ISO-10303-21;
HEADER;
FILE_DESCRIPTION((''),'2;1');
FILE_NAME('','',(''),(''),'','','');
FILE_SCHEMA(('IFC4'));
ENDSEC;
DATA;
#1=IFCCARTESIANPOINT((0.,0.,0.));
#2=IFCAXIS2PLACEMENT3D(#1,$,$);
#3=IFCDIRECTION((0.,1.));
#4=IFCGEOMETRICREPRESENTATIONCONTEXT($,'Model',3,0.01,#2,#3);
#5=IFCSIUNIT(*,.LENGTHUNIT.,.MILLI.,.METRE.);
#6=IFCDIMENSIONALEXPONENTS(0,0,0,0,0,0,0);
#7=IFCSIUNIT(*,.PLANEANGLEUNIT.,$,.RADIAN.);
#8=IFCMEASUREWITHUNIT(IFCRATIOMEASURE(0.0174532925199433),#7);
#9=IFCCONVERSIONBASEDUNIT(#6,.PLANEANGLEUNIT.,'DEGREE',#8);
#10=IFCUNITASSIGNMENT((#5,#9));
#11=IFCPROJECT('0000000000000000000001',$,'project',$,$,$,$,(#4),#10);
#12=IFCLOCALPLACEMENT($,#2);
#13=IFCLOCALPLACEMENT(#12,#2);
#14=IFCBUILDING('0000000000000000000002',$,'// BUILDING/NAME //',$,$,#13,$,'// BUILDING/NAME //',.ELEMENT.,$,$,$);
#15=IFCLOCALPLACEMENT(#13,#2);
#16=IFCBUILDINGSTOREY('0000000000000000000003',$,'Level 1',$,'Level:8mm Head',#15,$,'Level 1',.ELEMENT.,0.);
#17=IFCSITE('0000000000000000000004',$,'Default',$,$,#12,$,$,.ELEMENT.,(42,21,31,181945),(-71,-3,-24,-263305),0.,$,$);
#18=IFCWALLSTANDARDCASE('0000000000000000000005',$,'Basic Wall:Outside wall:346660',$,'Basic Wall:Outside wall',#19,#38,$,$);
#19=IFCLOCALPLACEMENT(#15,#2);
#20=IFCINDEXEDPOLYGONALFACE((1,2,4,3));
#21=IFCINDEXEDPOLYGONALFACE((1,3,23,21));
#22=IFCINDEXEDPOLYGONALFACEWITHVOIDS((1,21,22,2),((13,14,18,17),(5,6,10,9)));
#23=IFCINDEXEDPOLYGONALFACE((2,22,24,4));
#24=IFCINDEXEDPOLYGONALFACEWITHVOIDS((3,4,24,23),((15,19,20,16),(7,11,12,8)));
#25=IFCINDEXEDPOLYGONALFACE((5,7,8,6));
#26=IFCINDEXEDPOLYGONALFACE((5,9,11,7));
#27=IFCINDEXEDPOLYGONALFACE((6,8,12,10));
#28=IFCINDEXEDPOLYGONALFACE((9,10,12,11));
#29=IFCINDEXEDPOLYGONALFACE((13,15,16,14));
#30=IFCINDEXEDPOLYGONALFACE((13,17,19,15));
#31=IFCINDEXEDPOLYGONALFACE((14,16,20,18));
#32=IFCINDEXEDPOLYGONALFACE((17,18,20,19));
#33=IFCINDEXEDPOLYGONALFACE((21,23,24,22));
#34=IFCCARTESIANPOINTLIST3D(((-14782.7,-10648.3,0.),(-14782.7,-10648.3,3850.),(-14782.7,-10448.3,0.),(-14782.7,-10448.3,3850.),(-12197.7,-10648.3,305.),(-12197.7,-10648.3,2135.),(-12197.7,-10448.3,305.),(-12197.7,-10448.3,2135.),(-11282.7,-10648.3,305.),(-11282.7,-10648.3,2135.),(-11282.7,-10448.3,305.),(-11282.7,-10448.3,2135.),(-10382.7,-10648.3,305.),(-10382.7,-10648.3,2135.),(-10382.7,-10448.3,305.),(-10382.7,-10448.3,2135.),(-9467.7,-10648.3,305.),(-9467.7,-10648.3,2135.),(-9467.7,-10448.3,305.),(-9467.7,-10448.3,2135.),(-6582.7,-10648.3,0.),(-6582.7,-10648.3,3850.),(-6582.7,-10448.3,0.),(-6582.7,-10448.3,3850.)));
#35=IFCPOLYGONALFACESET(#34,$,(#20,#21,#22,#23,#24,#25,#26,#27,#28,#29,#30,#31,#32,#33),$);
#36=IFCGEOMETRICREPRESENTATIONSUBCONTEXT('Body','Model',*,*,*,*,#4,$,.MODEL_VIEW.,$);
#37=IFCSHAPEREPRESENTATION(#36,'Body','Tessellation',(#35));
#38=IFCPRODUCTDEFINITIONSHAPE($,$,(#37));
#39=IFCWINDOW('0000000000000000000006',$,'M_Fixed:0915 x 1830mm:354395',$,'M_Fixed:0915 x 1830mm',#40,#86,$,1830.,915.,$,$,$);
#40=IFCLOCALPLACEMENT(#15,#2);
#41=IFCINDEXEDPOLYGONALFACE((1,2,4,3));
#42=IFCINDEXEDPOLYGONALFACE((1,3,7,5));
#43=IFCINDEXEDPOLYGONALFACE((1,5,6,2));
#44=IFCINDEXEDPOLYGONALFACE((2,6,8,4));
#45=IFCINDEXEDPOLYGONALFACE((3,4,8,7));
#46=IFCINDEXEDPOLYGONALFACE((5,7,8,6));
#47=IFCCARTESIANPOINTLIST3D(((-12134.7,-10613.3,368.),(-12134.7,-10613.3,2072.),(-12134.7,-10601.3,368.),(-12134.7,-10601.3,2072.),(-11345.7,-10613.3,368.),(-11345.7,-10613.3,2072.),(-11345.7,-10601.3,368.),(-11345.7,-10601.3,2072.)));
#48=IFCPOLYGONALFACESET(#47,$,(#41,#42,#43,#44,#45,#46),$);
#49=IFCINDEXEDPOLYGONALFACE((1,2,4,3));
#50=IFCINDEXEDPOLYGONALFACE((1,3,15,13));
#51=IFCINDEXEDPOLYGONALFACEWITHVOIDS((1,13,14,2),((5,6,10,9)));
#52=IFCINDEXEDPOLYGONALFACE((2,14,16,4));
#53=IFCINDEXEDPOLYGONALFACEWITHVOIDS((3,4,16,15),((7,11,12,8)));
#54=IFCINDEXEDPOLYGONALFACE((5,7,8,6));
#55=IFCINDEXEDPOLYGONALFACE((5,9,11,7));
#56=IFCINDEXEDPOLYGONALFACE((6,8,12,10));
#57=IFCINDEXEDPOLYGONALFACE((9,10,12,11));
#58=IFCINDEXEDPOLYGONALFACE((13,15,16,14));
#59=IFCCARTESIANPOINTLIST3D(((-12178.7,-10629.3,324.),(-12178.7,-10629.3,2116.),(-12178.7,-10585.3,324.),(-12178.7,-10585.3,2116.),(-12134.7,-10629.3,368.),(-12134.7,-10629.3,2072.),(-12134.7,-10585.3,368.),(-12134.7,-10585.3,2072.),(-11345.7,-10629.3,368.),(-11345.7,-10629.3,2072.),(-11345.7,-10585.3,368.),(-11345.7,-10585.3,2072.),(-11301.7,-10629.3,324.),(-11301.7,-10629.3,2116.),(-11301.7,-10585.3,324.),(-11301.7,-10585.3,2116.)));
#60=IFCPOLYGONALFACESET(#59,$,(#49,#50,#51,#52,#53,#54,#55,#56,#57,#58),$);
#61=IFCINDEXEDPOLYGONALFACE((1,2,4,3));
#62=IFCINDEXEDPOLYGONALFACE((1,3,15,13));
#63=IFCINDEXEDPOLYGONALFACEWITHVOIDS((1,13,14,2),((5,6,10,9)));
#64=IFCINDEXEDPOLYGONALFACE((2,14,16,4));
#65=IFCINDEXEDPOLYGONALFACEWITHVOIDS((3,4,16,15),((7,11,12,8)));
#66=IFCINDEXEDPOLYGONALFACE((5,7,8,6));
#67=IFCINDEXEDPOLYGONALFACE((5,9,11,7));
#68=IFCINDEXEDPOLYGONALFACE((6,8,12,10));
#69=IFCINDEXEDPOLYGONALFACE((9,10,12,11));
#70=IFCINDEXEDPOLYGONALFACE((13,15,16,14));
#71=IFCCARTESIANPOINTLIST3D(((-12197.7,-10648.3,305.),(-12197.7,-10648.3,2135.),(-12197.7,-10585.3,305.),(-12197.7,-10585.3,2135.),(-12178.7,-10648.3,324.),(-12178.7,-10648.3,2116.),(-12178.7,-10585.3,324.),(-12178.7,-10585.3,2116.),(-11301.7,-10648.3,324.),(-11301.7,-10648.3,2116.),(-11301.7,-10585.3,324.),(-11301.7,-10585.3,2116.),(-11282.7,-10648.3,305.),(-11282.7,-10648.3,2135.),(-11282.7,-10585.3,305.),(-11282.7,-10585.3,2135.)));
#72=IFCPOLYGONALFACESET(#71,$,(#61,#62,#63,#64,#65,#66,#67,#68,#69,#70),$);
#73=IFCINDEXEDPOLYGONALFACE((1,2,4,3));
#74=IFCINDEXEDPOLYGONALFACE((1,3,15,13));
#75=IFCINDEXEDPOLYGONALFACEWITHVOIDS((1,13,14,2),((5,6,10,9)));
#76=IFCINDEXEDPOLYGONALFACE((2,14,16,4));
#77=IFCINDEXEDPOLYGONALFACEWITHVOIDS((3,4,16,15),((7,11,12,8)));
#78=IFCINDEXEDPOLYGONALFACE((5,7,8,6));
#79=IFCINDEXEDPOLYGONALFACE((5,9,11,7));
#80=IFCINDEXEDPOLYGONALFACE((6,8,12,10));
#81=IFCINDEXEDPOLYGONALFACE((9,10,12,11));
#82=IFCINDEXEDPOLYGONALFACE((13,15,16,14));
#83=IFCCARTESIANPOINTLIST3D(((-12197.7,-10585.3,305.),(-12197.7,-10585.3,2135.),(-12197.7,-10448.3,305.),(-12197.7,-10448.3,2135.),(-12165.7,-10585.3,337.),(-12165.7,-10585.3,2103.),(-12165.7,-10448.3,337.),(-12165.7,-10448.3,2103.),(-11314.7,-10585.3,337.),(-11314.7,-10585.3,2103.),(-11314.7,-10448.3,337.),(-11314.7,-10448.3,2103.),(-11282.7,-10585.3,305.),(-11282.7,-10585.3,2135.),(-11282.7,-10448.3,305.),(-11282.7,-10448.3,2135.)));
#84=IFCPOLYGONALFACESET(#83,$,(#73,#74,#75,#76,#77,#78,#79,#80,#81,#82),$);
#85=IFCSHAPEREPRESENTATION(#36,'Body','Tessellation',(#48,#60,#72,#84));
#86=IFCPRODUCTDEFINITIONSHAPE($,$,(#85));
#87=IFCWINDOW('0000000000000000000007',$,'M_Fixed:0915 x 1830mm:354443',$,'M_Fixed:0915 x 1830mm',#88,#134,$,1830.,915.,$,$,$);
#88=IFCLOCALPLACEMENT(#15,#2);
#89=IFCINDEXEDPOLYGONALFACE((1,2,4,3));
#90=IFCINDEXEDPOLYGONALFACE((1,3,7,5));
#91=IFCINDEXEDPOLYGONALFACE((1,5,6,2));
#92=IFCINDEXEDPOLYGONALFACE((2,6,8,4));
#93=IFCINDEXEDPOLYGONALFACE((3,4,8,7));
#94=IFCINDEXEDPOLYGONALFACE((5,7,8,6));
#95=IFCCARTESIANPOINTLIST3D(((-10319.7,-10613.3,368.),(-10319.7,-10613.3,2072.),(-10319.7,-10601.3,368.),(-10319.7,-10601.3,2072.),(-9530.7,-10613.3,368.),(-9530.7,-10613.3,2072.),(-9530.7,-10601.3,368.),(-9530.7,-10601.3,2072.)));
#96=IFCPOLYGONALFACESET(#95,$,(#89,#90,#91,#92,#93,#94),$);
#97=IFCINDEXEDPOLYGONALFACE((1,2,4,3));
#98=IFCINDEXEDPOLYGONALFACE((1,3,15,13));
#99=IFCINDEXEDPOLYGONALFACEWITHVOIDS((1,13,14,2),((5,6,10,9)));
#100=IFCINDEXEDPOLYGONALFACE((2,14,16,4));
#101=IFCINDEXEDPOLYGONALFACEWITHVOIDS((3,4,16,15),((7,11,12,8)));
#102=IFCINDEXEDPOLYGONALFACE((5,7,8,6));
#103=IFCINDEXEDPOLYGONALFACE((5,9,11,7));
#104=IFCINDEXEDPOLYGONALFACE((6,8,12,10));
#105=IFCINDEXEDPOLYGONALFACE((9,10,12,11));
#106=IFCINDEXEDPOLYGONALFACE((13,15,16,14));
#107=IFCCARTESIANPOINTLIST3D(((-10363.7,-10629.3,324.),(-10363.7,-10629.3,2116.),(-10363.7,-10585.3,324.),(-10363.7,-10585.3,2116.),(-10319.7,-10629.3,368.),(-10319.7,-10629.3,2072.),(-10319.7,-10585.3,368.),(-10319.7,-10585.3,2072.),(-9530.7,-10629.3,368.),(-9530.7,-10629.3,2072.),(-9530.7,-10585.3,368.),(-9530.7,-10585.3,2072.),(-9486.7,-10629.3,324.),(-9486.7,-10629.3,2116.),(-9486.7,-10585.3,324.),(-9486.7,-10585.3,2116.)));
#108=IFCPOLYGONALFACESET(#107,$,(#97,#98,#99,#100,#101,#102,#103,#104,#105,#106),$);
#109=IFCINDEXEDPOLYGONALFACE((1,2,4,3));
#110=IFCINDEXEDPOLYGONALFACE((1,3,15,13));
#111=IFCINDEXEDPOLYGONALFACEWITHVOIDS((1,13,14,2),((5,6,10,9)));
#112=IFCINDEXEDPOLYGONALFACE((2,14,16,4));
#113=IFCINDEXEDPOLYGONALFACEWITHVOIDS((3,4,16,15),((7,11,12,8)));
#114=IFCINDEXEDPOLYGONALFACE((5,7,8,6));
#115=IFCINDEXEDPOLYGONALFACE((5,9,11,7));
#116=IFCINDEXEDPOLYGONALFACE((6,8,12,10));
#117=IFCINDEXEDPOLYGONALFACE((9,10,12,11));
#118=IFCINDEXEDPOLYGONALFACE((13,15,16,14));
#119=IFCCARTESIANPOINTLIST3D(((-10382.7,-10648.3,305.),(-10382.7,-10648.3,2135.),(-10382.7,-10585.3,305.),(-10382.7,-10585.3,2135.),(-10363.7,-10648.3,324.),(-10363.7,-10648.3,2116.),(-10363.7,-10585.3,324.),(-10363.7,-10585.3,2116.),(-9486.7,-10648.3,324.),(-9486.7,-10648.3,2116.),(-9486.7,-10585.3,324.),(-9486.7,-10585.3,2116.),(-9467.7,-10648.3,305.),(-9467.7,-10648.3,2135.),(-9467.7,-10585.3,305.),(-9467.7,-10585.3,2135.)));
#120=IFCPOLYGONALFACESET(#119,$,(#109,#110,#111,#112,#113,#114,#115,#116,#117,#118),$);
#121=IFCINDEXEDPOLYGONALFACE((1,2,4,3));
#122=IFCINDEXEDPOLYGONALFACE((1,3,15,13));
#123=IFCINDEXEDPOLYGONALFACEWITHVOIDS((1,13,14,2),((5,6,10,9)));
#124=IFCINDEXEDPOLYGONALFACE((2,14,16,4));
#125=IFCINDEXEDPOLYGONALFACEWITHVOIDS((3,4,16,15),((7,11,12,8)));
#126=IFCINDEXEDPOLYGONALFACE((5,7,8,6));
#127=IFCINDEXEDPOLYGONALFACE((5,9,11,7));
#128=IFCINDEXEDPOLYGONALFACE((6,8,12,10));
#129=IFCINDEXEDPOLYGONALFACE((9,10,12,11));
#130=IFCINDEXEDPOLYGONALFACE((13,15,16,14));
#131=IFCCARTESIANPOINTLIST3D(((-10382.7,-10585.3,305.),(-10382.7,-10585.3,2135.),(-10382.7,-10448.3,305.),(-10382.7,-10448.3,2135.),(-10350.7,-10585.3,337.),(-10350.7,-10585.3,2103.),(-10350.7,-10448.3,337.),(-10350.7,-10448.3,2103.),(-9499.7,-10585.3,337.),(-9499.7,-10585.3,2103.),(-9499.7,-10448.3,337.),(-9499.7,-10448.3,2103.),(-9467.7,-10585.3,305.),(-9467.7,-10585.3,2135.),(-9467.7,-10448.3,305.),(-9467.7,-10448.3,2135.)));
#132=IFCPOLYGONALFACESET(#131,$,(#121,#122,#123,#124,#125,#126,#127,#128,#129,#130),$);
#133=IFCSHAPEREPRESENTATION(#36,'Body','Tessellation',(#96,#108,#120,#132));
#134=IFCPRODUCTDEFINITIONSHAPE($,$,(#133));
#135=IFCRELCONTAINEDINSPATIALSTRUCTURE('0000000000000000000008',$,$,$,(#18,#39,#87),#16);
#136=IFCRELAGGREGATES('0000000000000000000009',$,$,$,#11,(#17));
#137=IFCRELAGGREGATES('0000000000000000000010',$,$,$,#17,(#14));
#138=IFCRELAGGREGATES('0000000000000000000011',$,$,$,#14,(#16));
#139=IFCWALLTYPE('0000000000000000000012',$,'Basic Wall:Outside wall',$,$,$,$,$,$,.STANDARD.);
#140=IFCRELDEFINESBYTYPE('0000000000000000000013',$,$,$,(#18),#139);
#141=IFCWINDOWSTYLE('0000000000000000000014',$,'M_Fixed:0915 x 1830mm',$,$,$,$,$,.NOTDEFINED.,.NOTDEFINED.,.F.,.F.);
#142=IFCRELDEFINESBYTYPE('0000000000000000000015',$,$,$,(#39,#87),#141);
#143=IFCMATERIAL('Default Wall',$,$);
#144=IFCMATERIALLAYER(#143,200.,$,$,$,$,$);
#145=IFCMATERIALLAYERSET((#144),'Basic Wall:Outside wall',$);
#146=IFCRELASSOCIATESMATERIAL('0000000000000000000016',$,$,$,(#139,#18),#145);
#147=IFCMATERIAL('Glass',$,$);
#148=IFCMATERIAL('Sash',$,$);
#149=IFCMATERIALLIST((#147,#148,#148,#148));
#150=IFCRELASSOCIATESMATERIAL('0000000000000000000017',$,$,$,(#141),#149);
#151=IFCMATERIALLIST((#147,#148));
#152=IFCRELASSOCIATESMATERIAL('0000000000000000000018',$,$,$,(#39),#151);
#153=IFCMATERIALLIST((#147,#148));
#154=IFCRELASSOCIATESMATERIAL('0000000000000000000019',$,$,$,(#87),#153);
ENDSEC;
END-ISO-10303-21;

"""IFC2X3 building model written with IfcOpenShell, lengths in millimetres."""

from ifc_helpers import new_model, entity, si_unit, converted_unit, direction, frame, frame_2d, origin, place, context, subcontext, project, spatial, polyline, rectangle, outline, extrude, clip, bounded_halfspace, source, transform, mapped, material, material_list, layer, layer_set, layer_usage, type_object, type_shapes, element, fill, save


model = new_model("IFC2X3")

# Units and contexts
model_context = context("Model", 3, precision=0.01, world=origin(), true_north=direction((0.0, 1.0)))
body_context = subcontext(model_context, "Body", "Model", "MODEL_VIEW")
ifc_project = project(units=[si_unit("LENGTHUNIT", "METRE", prefix="MILLI"), converted_unit("PLANEANGLEUNIT", "DEGREE", entity("IfcRatioMeasure", 0.0174532925199433), si_unit("PLANEANGLEUNIT", "RADIAN"), dimensions=[0, 0, 0, 0, 0, 0, 0])], contexts=[model_context])

# Site, building, storey
site_placement = place(None, origin())
site = spatial("IfcSite", under=ifc_project, at=site_placement, Name="Default", CompositionType="ELEMENT", RefLatitude=(42, 21, 31, 181945), RefLongitude=(-71, -3, -24, -263305), RefElevation=0.0)
building_placement = place(site_placement, origin())
building = spatial("IfcBuilding", under=site, at=building_placement, Name="// BUILDING/NAME //", LongName="// BUILDING/NAME //", CompositionType="ELEMENT")
storey_placement = place(building_placement, origin())
storey = spatial("IfcBuildingStorey", under=building, at=storey_placement, Name="Level 1", ObjectType="Level:8mm Head", LongName="Level 1", CompositionType="ELEMENT", Elevation=0.0)

# Wall, openings, windows
ifc_material_1 = material(Name="Default Wall")
ifc_layer = layer(ifc_material_1, 200.0)
ifc_layer_set = layer_set([ifc_layer], Name="Basic Wall:Outside wall")
ifc_layer_usage_1 = layer_usage(ifc_layer_set, "AXIS2", "NEGATIVE", 100.0)
wall_type = type_object("IfcWallType", Name="Basic Wall:Outside wall", PredefinedType="STANDARD", material=ifc_layer_set)
wall_1_placement = place(storey_placement, frame((-14782.7, -10548.3, 0.0)))
wall_1 = element("IfcWallStandardCase", 1, at=wall_1_placement, inside=storey, type_object=wall_type, material=ifc_layer_usage_1, Name="Basic Wall:Outside wall:346660", ObjectType="Basic Wall:Outside wall", context=body_context, shape_type="Clipping", body=[
    clip(extrude(rectangle(XDim=8200.0, YDim=200.0, at=frame_2d((4100.0, 0.0), x_axis=(-1.0, 0.0))), origin(), (0.0, 0.0, 1.0), 3850.0), bounded_halfspace(frame((0.0, -100.0, 3850.0), z_axis=(0.0, 0.0, -1.0), x_axis=(1.0, 0.0, 0.0)), True, frame((0.0, -100.0, 3850.0)), polyline([(0.0, 0.0), (8200.0, 0.0), (8200.0, 200.0), (8000.0, 200.0), (200.0, 200.0), (0.0, 200.0), (0.0, 0.0)]))),
])
opening_1_placement = place(wall_1_placement, frame((3500.0, 100.0, 305.0)))
opening_1 = element("IfcOpeningElement", 2, at=opening_1_placement, cuts=wall_1, ObjectType="Opening", context=body_context, shape_type="SweptSolid", body=[
    extrude(rectangle(XDim=1830.0, YDim=915.0, at=frame_2d((915.0, 457.5), x_axis=(1.0, 0.0))), frame((0.0, 0.0, 0.0), z_axis=(0.0, -1.0, 0.0), x_axis=(0.0, 0.0, 1.0)), (0.0, 0.0, 1.0), 200.0),
])
opening_2_placement = place(wall_1_placement, frame((5315.0, 100.0, 305.0)))
opening_2 = element("IfcOpeningElement", 3, at=opening_2_placement, cuts=wall_1, ObjectType="Opening", context=body_context, shape_type="SweptSolid", body=[
    extrude(rectangle(XDim=1830.0, YDim=915.0, at=frame_2d((915.0, 457.5), x_axis=(1.0, 0.0))), frame((0.0, 0.0, 0.0), z_axis=(0.0, -1.0, 0.0), x_axis=(0.0, 0.0, 1.0)), (0.0, 0.0, 1.0), 200.0),
])
ifc_material_2 = material(Name="Glass")
ifc_material_3 = material(Name="Sash")
ifc_material_list_1 = material_list([ifc_material_2, ifc_material_3])
ifc_material_list_2 = material_list([ifc_material_2, ifc_material_3, ifc_material_3, ifc_material_3])
window_style = type_object("IfcWindowStyle", Name="M_Fixed:0915 x 1830mm", ConstructionType="NOTDEFINED", OperationType="NOTDEFINED", ParameterTakesPrecedence=False, Sizeable=False, material=ifc_material_list_2)
shared_shape_1 = source(origin(), body_context, "Body", "SweptSolid", [
    extrude(rectangle(XDim=12.0, YDim=789.0, at=frame_2d((0.0, 0.0), x_axis=(1.0, 0.0))), frame((457.5, 159.0, 63.0), z_axis=(0.0, 0.0, 1.0), x_axis=(0.0, -1.0, 0.0)), (0.0, 0.0, 1.0), 1704.0),
    extrude(outline(polyline([(-438.5, -896.0), (438.5, -896.0), (438.5, 896.0), (-438.5, 896.0), (-438.5, -896.0)]), holes=[polyline([(-394.5, -852.0), (-394.5, 852.0), (394.5, 852.0), (394.5, -852.0), (-394.5, -852.0)])]), frame((457.5, 137.0, 915.0), z_axis=(0.0, 1.0, 0.0), x_axis=(1.0, 0.0, 0.0)), (0.0, 0.0, 1.0), 44.0),
    extrude(outline(polyline([(-457.5, -915.0), (457.5, -915.0), (457.5, 915.0), (-457.5, 915.0), (-457.5, -915.0)]), holes=[polyline([(-438.5, -896.0), (-438.5, 896.0), (438.5, 896.0), (438.5, -896.0), (-438.5, -896.0)])]), frame((457.5, 137.0, 915.0), z_axis=(0.0, 1.0, 0.0), x_axis=(1.0, 0.0, 0.0)), (0.0, 0.0, 1.0), 63.0),
    extrude(outline(polyline([(-457.5, -915.0), (457.5, -915.0), (457.5, 915.0), (-457.5, 915.0), (-457.5, -915.0)]), holes=[polyline([(-425.5, -883.0), (-425.5, 883.0), (425.5, 883.0), (425.5, -883.0), (-425.5, -883.0)])]), frame((457.5, 0.0, 915.0), z_axis=(0.0, 1.0, 0.0), x_axis=(1.0, 0.0, 0.0)), (0.0, 0.0, 1.0), 137.0),
])
type_shapes(window_style, [shared_shape_1])
window_1_placement = place(opening_1_placement, frame((0.0, 0.0, 0.0), z_axis=(0.0, 0.0, 1.0), x_axis=(-1.0, 0.0, 0.0)))
window_1 = element("IfcWindow", 4, at=window_1_placement, inside=storey, type_object=window_style, material=ifc_material_list_1, Name="M_Fixed:0915 x 1830mm:354395", ObjectType="M_Fixed:0915 x 1830mm", OverallHeight=1830.0, OverallWidth=915.0, context=body_context, shape_type="MappedRepresentation", body=[
    mapped(shared_shape_1, transform((0.0, 0.0, 0.0), scale=1.0)),
])
fill(opening_1, window_1)
ifc_material_list_3 = material_list([ifc_material_2, ifc_material_3])
window_2_placement = place(opening_2_placement, frame((0.0, 0.0, 0.0), z_axis=(0.0, 0.0, 1.0), x_axis=(-1.0, 0.0, 0.0)))
window_2 = element("IfcWindow", 5, at=window_2_placement, inside=storey, type_object=window_style, material=ifc_material_list_3, Name="M_Fixed:0915 x 1830mm:354443", ObjectType="M_Fixed:0915 x 1830mm", OverallHeight=1830.0, OverallWidth=915.0, context=body_context, shape_type="MappedRepresentation", body=[
    mapped(shared_shape_1, transform((0.0, 0.0, 0.0), scale=1.0)),
])
fill(opening_2, window_2)

save(model, "model.ifc")
